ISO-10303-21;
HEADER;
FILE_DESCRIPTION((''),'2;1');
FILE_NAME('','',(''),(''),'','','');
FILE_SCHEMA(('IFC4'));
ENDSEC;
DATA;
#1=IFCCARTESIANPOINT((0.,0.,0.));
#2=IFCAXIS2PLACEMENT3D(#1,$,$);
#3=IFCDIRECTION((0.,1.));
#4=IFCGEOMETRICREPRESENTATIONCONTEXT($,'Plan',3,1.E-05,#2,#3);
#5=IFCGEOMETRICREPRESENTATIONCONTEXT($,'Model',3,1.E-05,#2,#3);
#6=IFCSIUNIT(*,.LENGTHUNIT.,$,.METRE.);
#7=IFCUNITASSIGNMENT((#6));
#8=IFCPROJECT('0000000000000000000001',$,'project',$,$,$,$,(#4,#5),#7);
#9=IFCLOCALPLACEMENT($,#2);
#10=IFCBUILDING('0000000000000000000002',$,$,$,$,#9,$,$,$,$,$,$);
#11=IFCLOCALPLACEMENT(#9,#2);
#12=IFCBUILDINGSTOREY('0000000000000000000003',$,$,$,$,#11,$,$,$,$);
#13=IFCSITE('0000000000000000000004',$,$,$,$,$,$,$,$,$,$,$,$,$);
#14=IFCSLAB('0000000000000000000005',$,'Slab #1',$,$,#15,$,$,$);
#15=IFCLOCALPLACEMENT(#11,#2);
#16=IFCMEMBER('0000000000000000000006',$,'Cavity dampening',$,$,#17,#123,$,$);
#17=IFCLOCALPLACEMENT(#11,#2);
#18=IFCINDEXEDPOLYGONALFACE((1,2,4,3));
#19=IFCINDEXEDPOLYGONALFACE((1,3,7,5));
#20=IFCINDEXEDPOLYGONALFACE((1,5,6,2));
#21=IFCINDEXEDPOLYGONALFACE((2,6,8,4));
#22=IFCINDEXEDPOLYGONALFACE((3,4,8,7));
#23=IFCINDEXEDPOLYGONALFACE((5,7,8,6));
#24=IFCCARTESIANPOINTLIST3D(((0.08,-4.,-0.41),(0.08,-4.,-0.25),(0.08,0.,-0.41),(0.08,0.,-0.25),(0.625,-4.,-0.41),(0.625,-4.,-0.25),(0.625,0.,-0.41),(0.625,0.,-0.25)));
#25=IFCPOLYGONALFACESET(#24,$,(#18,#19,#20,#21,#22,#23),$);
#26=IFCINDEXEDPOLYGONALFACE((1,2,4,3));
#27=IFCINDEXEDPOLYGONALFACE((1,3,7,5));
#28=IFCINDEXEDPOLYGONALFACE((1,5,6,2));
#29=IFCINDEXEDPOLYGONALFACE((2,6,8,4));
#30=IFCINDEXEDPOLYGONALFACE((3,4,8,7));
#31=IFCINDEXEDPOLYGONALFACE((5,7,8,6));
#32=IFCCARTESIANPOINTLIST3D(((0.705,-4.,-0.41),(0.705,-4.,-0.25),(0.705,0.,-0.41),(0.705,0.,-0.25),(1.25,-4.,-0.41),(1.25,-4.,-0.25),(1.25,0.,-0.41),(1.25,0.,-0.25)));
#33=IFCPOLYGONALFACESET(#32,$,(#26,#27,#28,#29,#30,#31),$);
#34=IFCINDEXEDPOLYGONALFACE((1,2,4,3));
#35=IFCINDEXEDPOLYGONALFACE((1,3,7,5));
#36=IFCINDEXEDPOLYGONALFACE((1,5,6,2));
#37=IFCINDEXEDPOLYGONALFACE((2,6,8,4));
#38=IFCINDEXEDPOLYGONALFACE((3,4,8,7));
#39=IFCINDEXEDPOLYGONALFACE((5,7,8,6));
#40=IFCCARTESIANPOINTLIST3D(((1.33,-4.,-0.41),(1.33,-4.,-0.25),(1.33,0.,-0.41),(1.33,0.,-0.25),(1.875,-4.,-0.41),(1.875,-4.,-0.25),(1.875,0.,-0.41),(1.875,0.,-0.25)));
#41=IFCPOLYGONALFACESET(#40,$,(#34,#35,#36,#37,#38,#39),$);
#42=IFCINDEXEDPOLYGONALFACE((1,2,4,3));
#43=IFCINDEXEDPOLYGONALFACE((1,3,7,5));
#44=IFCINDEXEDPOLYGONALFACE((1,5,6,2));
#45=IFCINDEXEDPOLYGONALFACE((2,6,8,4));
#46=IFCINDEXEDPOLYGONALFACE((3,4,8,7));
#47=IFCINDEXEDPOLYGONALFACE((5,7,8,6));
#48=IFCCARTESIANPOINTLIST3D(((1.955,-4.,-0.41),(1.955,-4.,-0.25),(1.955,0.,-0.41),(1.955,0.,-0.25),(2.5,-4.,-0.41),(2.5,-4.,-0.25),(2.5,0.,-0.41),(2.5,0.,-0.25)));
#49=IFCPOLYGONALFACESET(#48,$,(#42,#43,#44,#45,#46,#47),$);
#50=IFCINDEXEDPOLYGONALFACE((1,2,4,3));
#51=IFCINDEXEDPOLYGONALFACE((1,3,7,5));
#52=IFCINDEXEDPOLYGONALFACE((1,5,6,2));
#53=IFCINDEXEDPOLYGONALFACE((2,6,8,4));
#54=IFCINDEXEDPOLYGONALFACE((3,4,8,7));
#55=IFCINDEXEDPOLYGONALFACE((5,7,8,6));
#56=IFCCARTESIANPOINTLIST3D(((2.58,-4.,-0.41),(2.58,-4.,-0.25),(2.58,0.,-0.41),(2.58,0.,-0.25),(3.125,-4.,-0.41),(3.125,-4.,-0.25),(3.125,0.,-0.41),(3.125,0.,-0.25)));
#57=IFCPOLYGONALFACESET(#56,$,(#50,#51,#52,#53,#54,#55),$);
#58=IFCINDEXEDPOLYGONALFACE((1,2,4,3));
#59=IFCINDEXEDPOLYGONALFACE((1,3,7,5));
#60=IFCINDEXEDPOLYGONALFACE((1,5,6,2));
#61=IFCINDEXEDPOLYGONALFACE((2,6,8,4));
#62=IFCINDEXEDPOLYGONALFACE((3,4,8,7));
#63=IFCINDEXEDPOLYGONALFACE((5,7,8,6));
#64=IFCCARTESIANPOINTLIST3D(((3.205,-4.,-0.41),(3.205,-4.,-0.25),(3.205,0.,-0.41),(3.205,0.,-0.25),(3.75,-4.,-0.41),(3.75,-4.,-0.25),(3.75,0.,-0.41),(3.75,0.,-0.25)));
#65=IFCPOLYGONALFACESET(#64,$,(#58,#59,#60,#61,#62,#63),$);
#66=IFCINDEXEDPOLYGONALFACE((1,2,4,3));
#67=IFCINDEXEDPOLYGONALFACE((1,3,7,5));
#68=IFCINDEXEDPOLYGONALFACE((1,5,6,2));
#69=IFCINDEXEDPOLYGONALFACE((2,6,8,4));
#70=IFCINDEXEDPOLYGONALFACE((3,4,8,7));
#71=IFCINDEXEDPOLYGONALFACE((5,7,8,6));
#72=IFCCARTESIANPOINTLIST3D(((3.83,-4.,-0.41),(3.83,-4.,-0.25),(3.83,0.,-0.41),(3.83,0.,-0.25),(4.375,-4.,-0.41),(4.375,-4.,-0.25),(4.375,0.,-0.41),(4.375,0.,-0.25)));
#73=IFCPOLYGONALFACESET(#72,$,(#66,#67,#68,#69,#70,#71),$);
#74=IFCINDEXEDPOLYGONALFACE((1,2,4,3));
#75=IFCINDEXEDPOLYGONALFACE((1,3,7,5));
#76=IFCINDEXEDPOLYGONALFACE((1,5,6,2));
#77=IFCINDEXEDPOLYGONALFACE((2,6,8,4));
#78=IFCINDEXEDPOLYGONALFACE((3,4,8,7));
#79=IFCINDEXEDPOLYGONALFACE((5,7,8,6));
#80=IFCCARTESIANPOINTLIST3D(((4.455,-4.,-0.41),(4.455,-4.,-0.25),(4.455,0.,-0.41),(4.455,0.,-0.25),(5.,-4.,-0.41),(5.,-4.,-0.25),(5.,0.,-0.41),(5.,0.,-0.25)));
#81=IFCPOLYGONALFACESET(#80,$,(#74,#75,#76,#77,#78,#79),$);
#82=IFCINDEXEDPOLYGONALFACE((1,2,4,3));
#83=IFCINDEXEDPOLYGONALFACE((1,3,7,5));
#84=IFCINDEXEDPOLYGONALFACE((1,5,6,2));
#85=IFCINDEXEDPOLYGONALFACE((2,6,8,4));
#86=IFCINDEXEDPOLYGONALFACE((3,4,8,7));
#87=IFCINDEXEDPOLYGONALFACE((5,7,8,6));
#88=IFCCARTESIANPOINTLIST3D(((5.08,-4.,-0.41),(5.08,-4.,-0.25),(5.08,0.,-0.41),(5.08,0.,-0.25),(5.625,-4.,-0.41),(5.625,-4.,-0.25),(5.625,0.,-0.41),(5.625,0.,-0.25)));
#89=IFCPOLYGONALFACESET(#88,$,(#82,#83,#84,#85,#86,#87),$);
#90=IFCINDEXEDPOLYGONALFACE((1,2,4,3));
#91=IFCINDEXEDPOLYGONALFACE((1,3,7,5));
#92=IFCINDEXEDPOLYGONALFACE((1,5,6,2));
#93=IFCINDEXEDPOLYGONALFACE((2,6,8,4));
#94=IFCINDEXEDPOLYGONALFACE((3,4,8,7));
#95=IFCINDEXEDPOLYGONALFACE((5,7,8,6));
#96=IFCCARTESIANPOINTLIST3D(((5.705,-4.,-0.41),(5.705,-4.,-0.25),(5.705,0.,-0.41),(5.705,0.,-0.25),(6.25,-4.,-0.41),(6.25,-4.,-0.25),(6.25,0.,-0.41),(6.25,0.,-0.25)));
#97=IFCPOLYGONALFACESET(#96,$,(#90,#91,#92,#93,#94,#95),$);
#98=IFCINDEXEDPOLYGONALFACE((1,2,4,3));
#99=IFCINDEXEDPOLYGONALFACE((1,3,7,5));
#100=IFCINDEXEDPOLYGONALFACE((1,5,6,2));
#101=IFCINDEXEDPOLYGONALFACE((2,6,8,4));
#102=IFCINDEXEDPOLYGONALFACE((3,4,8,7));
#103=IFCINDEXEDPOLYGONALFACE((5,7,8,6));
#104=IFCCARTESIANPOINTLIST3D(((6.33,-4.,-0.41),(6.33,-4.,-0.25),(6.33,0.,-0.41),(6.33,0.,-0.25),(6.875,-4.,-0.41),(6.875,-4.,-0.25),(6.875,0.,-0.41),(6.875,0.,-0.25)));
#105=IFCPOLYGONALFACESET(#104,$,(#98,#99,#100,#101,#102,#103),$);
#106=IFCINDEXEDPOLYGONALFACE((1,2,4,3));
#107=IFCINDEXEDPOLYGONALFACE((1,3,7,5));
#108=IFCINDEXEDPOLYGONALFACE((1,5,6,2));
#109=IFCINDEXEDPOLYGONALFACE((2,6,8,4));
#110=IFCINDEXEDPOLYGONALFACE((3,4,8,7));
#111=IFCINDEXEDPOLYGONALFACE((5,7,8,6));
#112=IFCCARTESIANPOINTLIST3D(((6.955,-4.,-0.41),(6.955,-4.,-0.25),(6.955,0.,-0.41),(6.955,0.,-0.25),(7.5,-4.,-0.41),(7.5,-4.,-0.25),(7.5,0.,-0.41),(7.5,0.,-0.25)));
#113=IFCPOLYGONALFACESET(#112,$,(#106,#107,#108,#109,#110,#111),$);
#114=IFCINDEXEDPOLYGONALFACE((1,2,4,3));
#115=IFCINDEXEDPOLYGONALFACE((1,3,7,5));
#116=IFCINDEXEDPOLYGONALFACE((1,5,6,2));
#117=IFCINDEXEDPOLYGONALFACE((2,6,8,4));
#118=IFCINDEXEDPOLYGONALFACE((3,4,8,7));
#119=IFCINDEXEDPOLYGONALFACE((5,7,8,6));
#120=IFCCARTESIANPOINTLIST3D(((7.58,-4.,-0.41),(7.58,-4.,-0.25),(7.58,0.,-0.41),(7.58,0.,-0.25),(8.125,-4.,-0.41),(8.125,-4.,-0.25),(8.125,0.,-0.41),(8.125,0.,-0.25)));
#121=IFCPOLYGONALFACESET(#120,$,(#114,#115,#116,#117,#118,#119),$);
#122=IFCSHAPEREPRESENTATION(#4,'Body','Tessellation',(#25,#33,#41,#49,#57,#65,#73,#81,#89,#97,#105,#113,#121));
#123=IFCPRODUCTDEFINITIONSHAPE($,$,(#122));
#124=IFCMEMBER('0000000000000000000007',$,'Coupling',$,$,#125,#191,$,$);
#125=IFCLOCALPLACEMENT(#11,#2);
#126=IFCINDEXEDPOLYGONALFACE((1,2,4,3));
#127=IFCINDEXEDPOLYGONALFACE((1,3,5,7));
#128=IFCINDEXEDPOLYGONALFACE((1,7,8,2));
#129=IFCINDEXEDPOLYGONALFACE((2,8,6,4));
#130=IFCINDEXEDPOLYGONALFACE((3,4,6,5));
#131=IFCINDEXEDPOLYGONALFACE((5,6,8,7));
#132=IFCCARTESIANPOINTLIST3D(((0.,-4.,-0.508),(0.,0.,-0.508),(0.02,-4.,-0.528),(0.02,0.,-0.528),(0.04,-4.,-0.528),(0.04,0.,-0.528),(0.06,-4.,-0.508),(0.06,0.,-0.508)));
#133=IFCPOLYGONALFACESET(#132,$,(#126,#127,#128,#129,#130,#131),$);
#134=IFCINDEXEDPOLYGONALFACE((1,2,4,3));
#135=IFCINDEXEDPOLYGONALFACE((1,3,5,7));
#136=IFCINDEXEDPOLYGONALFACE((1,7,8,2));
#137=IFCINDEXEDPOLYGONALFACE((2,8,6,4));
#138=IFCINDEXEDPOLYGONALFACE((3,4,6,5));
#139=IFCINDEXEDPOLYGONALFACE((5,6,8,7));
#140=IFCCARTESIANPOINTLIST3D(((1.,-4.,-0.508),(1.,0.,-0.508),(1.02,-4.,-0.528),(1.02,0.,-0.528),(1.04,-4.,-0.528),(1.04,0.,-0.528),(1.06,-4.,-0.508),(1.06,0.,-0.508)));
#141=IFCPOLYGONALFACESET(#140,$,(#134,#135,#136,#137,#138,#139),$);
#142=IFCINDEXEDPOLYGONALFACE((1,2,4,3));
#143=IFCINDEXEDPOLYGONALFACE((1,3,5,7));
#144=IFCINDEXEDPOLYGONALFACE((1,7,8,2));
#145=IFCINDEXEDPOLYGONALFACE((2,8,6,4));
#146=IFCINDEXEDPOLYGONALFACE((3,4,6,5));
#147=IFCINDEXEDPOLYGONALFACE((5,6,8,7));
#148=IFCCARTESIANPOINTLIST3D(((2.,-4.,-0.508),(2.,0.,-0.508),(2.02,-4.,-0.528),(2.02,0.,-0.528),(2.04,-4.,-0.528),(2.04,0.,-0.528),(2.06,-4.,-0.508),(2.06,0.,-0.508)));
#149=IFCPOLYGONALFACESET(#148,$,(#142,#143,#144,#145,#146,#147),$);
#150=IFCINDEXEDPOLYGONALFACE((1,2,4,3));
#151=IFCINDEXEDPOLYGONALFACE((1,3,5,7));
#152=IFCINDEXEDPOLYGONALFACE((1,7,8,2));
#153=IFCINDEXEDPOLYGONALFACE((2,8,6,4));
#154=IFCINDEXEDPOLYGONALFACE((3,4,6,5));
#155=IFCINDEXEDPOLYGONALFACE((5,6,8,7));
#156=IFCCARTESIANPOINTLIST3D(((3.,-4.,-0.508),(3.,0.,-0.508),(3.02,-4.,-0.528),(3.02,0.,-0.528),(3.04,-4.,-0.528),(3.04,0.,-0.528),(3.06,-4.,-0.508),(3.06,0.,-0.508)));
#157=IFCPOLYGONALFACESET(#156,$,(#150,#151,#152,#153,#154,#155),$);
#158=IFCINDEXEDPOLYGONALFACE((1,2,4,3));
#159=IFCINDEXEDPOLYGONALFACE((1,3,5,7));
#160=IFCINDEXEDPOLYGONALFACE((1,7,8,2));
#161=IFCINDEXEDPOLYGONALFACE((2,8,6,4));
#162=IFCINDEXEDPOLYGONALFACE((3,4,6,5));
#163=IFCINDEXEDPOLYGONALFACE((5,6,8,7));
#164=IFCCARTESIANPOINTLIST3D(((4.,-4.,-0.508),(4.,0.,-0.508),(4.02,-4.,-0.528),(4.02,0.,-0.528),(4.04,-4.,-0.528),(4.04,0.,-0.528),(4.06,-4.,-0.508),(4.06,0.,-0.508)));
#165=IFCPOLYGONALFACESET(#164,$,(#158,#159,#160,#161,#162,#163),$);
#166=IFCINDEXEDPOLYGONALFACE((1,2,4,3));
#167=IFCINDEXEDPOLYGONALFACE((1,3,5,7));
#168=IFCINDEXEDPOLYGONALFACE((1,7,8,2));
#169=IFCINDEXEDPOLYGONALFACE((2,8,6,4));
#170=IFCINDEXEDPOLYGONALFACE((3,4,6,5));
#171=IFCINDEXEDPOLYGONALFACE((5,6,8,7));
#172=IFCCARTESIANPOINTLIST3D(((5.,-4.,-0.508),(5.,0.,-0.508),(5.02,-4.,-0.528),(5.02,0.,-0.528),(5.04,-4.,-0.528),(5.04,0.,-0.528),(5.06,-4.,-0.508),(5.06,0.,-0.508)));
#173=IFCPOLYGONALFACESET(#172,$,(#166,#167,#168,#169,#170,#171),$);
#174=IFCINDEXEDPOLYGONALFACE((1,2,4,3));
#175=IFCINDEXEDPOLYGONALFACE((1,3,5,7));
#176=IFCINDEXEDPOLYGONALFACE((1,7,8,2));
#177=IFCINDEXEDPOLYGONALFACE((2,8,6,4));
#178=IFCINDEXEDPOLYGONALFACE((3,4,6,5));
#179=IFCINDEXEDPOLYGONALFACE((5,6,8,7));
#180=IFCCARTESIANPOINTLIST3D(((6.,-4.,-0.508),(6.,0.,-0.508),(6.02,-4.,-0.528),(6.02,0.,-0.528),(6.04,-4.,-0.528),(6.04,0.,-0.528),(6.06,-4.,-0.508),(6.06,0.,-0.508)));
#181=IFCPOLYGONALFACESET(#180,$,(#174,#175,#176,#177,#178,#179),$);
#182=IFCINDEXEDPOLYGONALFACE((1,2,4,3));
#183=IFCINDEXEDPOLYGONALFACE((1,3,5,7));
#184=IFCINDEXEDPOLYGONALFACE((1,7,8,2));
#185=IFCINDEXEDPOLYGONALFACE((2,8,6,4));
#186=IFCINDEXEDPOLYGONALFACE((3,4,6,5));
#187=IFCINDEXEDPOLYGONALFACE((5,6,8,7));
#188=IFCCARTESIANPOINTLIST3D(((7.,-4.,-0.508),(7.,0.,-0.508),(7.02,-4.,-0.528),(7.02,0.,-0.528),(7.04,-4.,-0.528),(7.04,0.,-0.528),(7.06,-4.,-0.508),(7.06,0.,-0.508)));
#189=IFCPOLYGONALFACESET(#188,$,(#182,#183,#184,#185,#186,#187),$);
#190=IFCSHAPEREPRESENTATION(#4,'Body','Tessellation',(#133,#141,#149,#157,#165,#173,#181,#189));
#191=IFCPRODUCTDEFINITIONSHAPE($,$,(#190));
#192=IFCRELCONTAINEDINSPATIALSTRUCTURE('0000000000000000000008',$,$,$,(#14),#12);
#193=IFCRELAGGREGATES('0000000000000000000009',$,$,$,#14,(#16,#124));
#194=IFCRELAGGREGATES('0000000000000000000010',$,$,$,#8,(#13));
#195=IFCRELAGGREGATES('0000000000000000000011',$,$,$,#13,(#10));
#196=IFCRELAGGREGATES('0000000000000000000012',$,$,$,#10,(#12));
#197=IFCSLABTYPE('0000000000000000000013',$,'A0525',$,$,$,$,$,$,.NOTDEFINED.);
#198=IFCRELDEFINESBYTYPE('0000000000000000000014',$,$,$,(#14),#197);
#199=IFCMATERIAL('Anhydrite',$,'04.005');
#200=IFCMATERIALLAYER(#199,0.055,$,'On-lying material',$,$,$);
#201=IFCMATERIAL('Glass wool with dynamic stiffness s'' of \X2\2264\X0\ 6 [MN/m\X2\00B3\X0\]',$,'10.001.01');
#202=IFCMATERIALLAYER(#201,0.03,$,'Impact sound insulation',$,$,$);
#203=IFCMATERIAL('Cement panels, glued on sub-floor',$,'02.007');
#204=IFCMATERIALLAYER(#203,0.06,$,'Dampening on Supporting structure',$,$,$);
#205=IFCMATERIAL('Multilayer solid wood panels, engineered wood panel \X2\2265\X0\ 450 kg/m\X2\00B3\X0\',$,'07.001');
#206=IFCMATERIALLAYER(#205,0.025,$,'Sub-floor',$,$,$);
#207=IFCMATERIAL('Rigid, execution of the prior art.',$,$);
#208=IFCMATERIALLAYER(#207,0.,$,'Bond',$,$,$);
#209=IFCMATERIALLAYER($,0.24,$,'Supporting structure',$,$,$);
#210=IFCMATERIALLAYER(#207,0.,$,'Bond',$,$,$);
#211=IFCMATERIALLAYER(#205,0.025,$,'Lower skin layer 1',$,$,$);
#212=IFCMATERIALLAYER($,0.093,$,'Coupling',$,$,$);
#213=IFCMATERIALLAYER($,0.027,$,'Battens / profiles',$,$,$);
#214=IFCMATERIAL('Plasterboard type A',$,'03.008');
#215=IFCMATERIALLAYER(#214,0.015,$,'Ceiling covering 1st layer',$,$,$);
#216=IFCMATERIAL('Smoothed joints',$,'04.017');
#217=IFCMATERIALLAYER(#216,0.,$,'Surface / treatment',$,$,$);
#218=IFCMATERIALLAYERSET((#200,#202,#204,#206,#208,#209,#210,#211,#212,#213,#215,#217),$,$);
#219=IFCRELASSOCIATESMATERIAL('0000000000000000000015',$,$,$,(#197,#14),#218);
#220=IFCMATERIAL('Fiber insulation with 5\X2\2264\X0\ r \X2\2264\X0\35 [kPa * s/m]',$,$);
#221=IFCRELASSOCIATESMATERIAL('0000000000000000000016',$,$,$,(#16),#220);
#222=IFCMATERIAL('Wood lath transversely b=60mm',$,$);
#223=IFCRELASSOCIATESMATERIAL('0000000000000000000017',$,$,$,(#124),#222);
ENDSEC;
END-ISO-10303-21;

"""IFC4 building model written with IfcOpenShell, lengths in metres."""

from ifc_helpers import new_model, si_unit, direction, frame, frame_2d, origin, place, context, project, spatial, polyline, rectangle, outline, extrude, material, layer, layer_set, type_object, element, aggregate, save


model = new_model("IFC4")

# Units and contexts
plan_context = context("Plan", 3, precision=1e-05, world=origin(), true_north=direction((0.0, 1.0)))
model_context = context("Model", 3, precision=1e-05, world=origin(), true_north=direction((0.0, 1.0)))
ifc_project = project(units=[si_unit("LENGTHUNIT", "METRE")], contexts=[plan_context, model_context])

# Site, building, storey
site = spatial("IfcSite", under=ifc_project)
building_placement = place(None, origin())
building = spatial("IfcBuilding", under=site, at=building_placement)
storey_placement = place(building_placement, origin())
storey = spatial("IfcBuildingStorey", under=building, at=storey_placement)

# Slab, members
ifc_material_1 = material(Name="Anhydrite", Category="04.005")
ifc_layer_1 = layer(ifc_material_1, 0.055, Name="On-lying material")
ifc_material_2 = material(Name="Glass wool with dynamic stiffness s' of ≤ 6 [MN/m³]", Category="10.001.01")
ifc_layer_2 = layer(ifc_material_2, 0.03, Name="Impact sound insulation")
ifc_material_3 = material(Name="Cement panels, glued on sub-floor", Category="02.007")
ifc_layer_3 = layer(ifc_material_3, 0.06, Name="Dampening on Supporting structure")
ifc_material_4 = material(Name="Multilayer solid wood panels, engineered wood panel ≥ 450 kg/m³", Category="07.001")
ifc_layer_4 = layer(ifc_material_4, 0.025, Name="Sub-floor")
ifc_material_5 = material(Name="Rigid, execution of the prior art.")
ifc_layer_5 = layer(ifc_material_5, 0.0, Name="Bond")
ifc_layer_6 = layer(None, 0.24, Name="Supporting structure")
ifc_layer_7 = layer(ifc_material_5, 0.0, Name="Bond")
ifc_layer_8 = layer(ifc_material_4, 0.025, Name="Lower skin layer 1")
ifc_layer_9 = layer(None, 0.093, Name="Coupling")
ifc_layer_10 = layer(None, 0.027, Name="Battens / profiles")
ifc_material_6 = material(Name="Plasterboard type A", Category="03.008")
ifc_layer_11 = layer(ifc_material_6, 0.015, Name="Ceiling covering 1st layer")
ifc_material_7 = material(Name="Smoothed joints", Category="04.017")
ifc_layer_12 = layer(ifc_material_7, 0.0, Name="Surface / treatment")
ifc_layer_set = layer_set([ifc_layer_1, ifc_layer_2, ifc_layer_3, ifc_layer_4, ifc_layer_5, ifc_layer_6, ifc_layer_7, ifc_layer_8, ifc_layer_9, ifc_layer_10, ifc_layer_11, ifc_layer_12])
slab_type = type_object("IfcSlabType", Name="A0525", PredefinedType="NOTDEFINED", material=ifc_layer_set)
slab_placement = place(None, frame((0.0, 0.0, 0.0), z_axis=(0.0, 0.0, -1.0), x_axis=(1.0, 0.0, 0.0)))
slab = element("IfcSlab", 1, at=slab_placement, inside=storey, type_object=slab_type, material=ifc_layer_set, Name="Slab #1")
ifc_material_8 = material(Name="Fiber insulation with 5≤ r ≤35 [kPa * s/m]")
member_1_placement = place(slab_placement, origin())
member_1 = element("IfcMember", 2, at=member_1_placement, material=ifc_material_8, Name="Cavity dampening", context=plan_context, shape_type="SweptSolid", body=[
    extrude(rectangle(XDim=0.545, YDim=0.16, at=frame_2d((0.2725, 0.08), x_axis=(1.0, 0.0))), frame((0.08, 4.0, 0.25), z_axis=(0.0, -1.0, 0.0), x_axis=(1.0, 0.0, 0.0)), (0.0, 0.0, 1.0), 4.0),
    extrude(rectangle(XDim=0.545, YDim=0.16, at=frame_2d((0.2725, 0.08), x_axis=(1.0, 0.0))), frame((0.705, 4.0, 0.25), z_axis=(0.0, -1.0, 0.0), x_axis=(1.0, 0.0, 0.0)), (0.0, 0.0, 1.0), 4.0),
    extrude(rectangle(XDim=0.545, YDim=0.16, at=frame_2d((0.2725, 0.08), x_axis=(1.0, 0.0))), frame((1.33, 4.0, 0.25), z_axis=(0.0, -1.0, 0.0), x_axis=(1.0, 0.0, 0.0)), (0.0, 0.0, 1.0), 4.0),
    extrude(rectangle(XDim=0.545, YDim=0.16, at=frame_2d((0.2725, 0.08), x_axis=(1.0, 0.0))), frame((1.955, 4.0, 0.25), z_axis=(0.0, -1.0, 0.0), x_axis=(1.0, 0.0, 0.0)), (0.0, 0.0, 1.0), 4.0),
    extrude(rectangle(XDim=0.545, YDim=0.16, at=frame_2d((0.2725, 0.08), x_axis=(1.0, 0.0))), frame((2.58, 4.0, 0.25), z_axis=(0.0, -1.0, 0.0), x_axis=(1.0, 0.0, 0.0)), (0.0, 0.0, 1.0), 4.0),
    extrude(rectangle(XDim=0.545, YDim=0.16, at=frame_2d((0.2725, 0.08), x_axis=(1.0, 0.0))), frame((3.205, 4.0, 0.25), z_axis=(0.0, -1.0, 0.0), x_axis=(1.0, 0.0, 0.0)), (0.0, 0.0, 1.0), 4.0),
    extrude(rectangle(XDim=0.545, YDim=0.16, at=frame_2d((0.2725, 0.08), x_axis=(1.0, 0.0))), frame((3.83, 4.0, 0.25), z_axis=(0.0, -1.0, 0.0), x_axis=(1.0, 0.0, 0.0)), (0.0, 0.0, 1.0), 4.0),
    extrude(rectangle(XDim=0.545, YDim=0.16, at=frame_2d((0.2725, 0.08), x_axis=(1.0, 0.0))), frame((4.455, 4.0, 0.25), z_axis=(0.0, -1.0, 0.0), x_axis=(1.0, 0.0, 0.0)), (0.0, 0.0, 1.0), 4.0),
    extrude(rectangle(XDim=0.545, YDim=0.16, at=frame_2d((0.2725, 0.08), x_axis=(1.0, 0.0))), frame((5.08, 4.0, 0.25), z_axis=(0.0, -1.0, 0.0), x_axis=(1.0, 0.0, 0.0)), (0.0, 0.0, 1.0), 4.0),
    extrude(rectangle(XDim=0.545, YDim=0.16, at=frame_2d((0.2725, 0.08), x_axis=(1.0, 0.0))), frame((5.705, 4.0, 0.25), z_axis=(0.0, -1.0, 0.0), x_axis=(1.0, 0.0, 0.0)), (0.0, 0.0, 1.0), 4.0),
    extrude(rectangle(XDim=0.545, YDim=0.16, at=frame_2d((0.2725, 0.08), x_axis=(1.0, 0.0))), frame((6.33, 4.0, 0.25), z_axis=(0.0, -1.0, 0.0), x_axis=(1.0, 0.0, 0.0)), (0.0, 0.0, 1.0), 4.0),
    extrude(rectangle(XDim=0.545, YDim=0.16, at=frame_2d((0.2725, 0.08), x_axis=(1.0, 0.0))), frame((6.955, 4.0, 0.25), z_axis=(0.0, -1.0, 0.0), x_axis=(1.0, 0.0, 0.0)), (0.0, 0.0, 1.0), 4.0),
    extrude(rectangle(XDim=0.545, YDim=0.16, at=frame_2d((0.2725, 0.08), x_axis=(1.0, 0.0))), frame((7.58, 4.0, 0.25), z_axis=(0.0, -1.0, 0.0), x_axis=(1.0, 0.0, 0.0)), (0.0, 0.0, 1.0), 4.0),
])
ifc_material_9 = material(Name="Wood lath transversely b=60mm")
member_2_placement = place(slab_placement, origin())
member_2 = element("IfcMember", 3, at=member_2_placement, material=ifc_material_9, Name="Coupling", context=plan_context, shape_type="SweptSolid", body=[
    extrude(outline(polyline([(0.0, 0.0), (0.06, 0.0), (0.04, 0.02), (0.02, 0.02), (0.0, 0.0)])), frame((0.0, 4.0, 0.508), z_axis=(0.0, -1.0, 0.0), x_axis=(1.0, 0.0, 0.0)), (0.0, 0.0, 1.0), 4.0),
    extrude(outline(polyline([(0.0, 0.0), (0.06, 0.0), (0.04, 0.02), (0.02, 0.02), (0.0, 0.0)])), frame((1.0, 4.0, 0.508), z_axis=(0.0, -1.0, 0.0), x_axis=(1.0, 0.0, 0.0)), (0.0, 0.0, 1.0), 4.0),
    extrude(outline(polyline([(0.0, 0.0), (0.06, 0.0), (0.04, 0.02), (0.02, 0.02), (0.0, 0.0)])), frame((2.0, 4.0, 0.508), z_axis=(0.0, -1.0, 0.0), x_axis=(1.0, 0.0, 0.0)), (0.0, 0.0, 1.0), 4.0),
    extrude(outline(polyline([(0.0, 0.0), (0.06, 0.0), (0.04, 0.02), (0.02, 0.02), (0.0, 0.0)])), frame((3.0, 4.0, 0.508), z_axis=(0.0, -1.0, 0.0), x_axis=(1.0, 0.0, 0.0)), (0.0, 0.0, 1.0), 4.0),
    extrude(outline(polyline([(0.0, 0.0), (0.06, 0.0), (0.04, 0.02), (0.02, 0.02), (0.0, 0.0)])), frame((4.0, 4.0, 0.508), z_axis=(0.0, -1.0, 0.0), x_axis=(1.0, 0.0, 0.0)), (0.0, 0.0, 1.0), 4.0),
    extrude(outline(polyline([(0.0, 0.0), (0.06, 0.0), (0.04, 0.02), (0.02, 0.02), (0.0, 0.0)])), frame((5.0, 4.0, 0.508), z_axis=(0.0, -1.0, 0.0), x_axis=(1.0, 0.0, 0.0)), (0.0, 0.0, 1.0), 4.0),
    extrude(outline(polyline([(0.0, 0.0), (0.06, 0.0), (0.04, 0.02), (0.02, 0.02), (0.0, 0.0)])), frame((6.0, 4.0, 0.508), z_axis=(0.0, -1.0, 0.0), x_axis=(1.0, 0.0, 0.0)), (0.0, 0.0, 1.0), 4.0),
    extrude(outline(polyline([(0.0, 0.0), (0.06, 0.0), (0.04, 0.02), (0.02, 0.02), (0.0, 0.0)])), frame((7.0, 4.0, 0.508), z_axis=(0.0, -1.0, 0.0), x_axis=(1.0, 0.0, 0.0)), (0.0, 0.0, 1.0), 4.0),
])
aggregate(slab, [member_1, member_2])

save(model, "model.ifc")
